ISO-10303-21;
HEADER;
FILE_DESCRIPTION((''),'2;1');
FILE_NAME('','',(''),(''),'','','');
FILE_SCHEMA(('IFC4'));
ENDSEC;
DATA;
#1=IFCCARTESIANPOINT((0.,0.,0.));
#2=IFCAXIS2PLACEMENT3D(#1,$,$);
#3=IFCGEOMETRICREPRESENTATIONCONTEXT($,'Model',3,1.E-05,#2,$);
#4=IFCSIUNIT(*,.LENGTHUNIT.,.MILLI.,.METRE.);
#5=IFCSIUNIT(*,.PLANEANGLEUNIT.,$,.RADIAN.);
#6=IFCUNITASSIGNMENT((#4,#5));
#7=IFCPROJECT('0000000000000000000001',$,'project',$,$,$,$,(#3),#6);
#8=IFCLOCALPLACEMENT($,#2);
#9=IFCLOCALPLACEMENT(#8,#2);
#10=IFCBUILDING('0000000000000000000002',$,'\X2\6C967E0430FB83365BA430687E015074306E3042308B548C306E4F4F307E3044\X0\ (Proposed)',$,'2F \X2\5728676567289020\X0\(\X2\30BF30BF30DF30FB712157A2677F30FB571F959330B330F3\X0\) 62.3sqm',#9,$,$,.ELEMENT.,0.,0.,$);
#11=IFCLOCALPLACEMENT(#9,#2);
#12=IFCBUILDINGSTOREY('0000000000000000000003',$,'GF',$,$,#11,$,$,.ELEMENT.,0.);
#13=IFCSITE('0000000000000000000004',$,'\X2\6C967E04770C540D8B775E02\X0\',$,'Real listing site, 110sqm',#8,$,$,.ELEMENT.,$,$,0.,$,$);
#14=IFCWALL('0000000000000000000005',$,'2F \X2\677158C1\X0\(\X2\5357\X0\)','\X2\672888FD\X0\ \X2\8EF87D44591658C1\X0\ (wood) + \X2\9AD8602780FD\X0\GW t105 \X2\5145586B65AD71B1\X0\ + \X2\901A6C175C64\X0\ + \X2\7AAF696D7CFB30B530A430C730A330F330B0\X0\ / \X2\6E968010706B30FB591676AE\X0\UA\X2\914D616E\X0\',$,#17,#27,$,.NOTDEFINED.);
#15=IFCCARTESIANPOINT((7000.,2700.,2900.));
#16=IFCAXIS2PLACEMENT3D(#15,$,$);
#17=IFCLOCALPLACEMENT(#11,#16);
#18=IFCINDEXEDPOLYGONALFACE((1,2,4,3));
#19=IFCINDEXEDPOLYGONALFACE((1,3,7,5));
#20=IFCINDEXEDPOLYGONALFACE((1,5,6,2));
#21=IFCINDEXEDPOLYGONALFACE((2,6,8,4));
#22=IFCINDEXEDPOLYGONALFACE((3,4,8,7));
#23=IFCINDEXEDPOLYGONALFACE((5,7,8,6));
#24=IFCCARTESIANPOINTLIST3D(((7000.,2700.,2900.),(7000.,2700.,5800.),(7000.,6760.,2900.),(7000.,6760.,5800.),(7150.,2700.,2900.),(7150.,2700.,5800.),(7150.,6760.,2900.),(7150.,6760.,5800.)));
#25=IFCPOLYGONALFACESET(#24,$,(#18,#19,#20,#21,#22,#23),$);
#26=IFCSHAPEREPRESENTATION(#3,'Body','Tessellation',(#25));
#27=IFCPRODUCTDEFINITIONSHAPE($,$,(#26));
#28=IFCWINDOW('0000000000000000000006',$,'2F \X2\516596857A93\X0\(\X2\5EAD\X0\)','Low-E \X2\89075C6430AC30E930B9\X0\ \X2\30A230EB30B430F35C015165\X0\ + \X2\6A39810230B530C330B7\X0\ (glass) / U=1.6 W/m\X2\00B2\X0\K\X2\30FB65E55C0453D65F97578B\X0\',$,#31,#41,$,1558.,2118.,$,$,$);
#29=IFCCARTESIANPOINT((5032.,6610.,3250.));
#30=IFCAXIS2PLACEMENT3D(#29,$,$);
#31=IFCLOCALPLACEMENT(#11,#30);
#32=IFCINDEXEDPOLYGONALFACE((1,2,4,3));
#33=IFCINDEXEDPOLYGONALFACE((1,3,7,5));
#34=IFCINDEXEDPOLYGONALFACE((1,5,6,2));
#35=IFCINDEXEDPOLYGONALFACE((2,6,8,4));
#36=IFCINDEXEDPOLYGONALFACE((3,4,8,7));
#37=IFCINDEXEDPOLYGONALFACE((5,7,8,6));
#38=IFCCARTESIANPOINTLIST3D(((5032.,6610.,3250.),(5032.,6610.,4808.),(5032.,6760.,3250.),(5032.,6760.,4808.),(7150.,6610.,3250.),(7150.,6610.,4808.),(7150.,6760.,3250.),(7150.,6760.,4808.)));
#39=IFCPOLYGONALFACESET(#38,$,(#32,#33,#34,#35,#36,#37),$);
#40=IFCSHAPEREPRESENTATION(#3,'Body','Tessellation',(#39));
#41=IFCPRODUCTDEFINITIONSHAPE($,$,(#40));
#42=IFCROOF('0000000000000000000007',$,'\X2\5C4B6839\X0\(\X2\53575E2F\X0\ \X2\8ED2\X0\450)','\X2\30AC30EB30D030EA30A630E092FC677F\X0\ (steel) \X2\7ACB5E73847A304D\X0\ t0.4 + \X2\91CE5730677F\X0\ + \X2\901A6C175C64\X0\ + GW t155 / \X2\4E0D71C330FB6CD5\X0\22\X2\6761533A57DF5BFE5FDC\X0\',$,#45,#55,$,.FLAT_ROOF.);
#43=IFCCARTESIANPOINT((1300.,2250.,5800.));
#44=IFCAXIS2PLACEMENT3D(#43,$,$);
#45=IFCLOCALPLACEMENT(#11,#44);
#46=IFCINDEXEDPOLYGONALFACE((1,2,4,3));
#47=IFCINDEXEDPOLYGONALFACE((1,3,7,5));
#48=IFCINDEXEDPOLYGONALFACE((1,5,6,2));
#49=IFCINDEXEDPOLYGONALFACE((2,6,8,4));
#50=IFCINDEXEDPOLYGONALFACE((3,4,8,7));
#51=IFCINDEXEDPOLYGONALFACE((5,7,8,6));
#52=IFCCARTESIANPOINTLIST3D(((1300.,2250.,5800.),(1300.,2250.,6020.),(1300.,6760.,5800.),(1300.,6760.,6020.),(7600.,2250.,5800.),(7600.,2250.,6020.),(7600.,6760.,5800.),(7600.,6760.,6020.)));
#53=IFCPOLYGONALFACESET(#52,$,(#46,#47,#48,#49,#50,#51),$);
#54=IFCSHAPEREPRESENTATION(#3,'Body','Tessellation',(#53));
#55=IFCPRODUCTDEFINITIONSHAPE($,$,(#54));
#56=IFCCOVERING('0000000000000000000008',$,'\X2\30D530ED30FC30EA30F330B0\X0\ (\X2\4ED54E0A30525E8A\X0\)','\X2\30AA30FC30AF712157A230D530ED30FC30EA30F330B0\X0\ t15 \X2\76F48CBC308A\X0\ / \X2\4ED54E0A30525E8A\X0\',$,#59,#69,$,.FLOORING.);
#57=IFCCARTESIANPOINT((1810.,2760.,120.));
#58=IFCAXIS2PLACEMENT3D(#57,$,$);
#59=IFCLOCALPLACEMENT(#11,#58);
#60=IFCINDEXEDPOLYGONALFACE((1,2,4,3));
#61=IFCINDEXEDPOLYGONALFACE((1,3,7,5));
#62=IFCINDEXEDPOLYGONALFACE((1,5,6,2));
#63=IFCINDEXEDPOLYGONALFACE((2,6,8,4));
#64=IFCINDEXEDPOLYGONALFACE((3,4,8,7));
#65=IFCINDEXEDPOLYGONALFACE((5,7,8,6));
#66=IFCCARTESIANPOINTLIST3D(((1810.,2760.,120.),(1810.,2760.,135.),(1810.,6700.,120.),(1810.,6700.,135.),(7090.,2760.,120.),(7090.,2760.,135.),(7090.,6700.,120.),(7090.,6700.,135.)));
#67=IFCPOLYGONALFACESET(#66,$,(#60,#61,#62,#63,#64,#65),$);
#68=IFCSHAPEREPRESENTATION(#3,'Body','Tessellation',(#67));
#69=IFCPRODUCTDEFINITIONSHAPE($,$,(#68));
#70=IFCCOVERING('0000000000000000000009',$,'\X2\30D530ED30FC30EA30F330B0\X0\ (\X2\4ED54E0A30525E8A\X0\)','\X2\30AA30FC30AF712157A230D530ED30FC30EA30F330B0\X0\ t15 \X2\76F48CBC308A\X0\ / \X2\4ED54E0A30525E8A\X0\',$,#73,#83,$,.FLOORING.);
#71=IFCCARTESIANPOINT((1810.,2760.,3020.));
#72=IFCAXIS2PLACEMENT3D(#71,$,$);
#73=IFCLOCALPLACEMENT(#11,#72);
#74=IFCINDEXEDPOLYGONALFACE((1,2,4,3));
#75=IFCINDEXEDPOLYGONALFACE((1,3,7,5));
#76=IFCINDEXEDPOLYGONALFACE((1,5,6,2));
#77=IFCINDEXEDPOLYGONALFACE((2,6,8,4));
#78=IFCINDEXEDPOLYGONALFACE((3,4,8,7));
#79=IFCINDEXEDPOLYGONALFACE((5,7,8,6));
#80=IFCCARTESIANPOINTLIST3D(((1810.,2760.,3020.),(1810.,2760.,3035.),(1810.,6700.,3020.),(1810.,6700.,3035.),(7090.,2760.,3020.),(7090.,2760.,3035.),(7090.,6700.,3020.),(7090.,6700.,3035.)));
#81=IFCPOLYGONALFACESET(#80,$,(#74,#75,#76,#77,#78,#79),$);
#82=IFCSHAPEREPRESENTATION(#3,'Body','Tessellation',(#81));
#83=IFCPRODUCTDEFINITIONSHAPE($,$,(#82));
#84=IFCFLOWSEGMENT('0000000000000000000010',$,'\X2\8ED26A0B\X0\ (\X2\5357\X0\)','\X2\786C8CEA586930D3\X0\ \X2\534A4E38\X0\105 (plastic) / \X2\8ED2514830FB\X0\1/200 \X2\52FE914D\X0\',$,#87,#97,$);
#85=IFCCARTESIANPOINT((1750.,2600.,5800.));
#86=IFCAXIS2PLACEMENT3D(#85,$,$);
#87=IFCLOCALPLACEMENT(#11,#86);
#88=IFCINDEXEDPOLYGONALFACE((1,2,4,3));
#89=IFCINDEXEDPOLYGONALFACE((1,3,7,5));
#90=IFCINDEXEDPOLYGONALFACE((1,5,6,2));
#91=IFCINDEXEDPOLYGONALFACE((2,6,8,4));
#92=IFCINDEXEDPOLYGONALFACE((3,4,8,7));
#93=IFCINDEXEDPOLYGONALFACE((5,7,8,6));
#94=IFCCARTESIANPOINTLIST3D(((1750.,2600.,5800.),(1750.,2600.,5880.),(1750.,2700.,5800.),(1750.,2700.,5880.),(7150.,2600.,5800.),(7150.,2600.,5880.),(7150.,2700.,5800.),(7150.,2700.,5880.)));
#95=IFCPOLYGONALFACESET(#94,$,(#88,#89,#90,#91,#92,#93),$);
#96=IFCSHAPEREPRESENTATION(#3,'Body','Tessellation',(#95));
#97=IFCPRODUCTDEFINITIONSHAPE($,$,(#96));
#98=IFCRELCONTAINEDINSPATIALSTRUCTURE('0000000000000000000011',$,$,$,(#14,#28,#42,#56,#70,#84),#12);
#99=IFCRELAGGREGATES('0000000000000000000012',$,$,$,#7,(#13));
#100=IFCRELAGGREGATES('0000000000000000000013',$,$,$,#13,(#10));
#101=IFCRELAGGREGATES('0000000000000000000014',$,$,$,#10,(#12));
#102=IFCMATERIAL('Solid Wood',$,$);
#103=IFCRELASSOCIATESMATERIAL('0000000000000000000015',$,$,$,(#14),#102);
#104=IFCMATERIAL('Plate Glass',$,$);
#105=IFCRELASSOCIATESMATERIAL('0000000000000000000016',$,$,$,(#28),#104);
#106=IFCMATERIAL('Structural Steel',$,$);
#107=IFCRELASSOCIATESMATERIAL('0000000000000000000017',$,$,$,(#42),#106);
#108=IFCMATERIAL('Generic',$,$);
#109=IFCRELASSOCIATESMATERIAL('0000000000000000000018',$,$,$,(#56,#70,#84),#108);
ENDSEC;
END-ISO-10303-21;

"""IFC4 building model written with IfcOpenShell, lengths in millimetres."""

from ifc_helpers import new_model, si_unit, frame, frame_2d, origin, place, context, project, spatial, rectangle, extrude, material, element, fill, save


model = new_model("IFC4")

# Units and contexts
model_context = context("Model", 3, precision=1e-05, world=origin())
ifc_project = project(units=[si_unit("LENGTHUNIT", "METRE", prefix="MILLI"), si_unit("PLANEANGLEUNIT", "RADIAN")], contexts=[model_context])

# Site, building, storey
site_placement = place(None, origin())
site = spatial("IfcSite", under=ifc_project, at=site_placement, Name="沖縄県名護市", ObjectType="Real listing site, 110sqm", CompositionType="ELEMENT", RefElevation=0.0)
building_placement = place(site_placement, origin())
building = spatial("IfcBuilding", under=site, at=building_placement, Name="沖縄・茶室と縁側のある和の住まい (Proposed)", ObjectType="2F 在来木造(タタミ・無垢板・土間コン) 62.3sqm", CompositionType="ELEMENT", ElevationOfRefHeight=0.0, ElevationOfTerrain=0.0)
storey_placement = place(building_placement, origin())
storey = spatial("IfcBuildingStorey", under=building, at=storey_placement, Name="GF", CompositionType="ELEMENT", Elevation=0.0)

# Shared definitions
ifc_material_1 = material(Name="Solid Wood")

# Wall, opening, window
ifc_material_2 = material(Name="Plate Glass")
wall_1_placement = place(storey_placement, frame((7000.0, 2700.0, 2900.0)))
wall_1 = element("IfcWall", 1, at=wall_1_placement, inside=storey, material=ifc_material_1, Name="2F 東壁(南)", Description="木製 軸組外壁 (wood) + 高性能GW t105 充填断熱 + 通気層 + 窯業系サイディング / 準耐火・外皮UA配慮", PredefinedType="NOTDEFINED", context=model_context, shape_type="SweptSolid", body=[
    extrude(rectangle(XDim=150.0, YDim=4060.0, at=frame_2d((75.0, 2030.0))), frame((7000.0, 2700.0, 2900.0)), (0.0, 0.0, 1.0), 2900.0),
])
opening_1_placement = place(storey_placement, frame((5032.0, 6610.0, 3250.0)))
opening_1 = element("IfcOpeningElement", 2, at=opening_1_placement, cuts=wall_1, PredefinedType="NOTDEFINED", context=model_context, shape_type="SweptSolid", body=[
    extrude(rectangle(XDim=2118.0, YDim=150.0, at=frame_2d((1059.0, 75.0))), frame((5032.0, 6610.0, 3250.0)), (0.0, 0.0, 1.0), 1558.0),
])
window_1_placement = place(storey_placement, frame((5032.0, 6610.0, 3250.0)))
window_1 = element("IfcWindow", 3, at=window_1_placement, inside=storey, material=ifc_material_2, Name="2F 入隅窓(庭)", Description="Low-E 複層ガラス アルゴン封入 + 樹脂サッシ (glass) / U=1.6 W/m²K・日射取得型", OverallHeight=1558.0, OverallWidth=2118.0, context=model_context, shape_type="SweptSolid", body=[
    extrude(rectangle(XDim=2118.0, YDim=150.0, at=frame_2d((1059.0, 75.0))), frame((5032.0, 6610.0, 3250.0)), (0.0, 0.0, 1.0), 1558.0),
])
fill(opening_1, window_1)

# Roof
ifc_material_3 = material(Name="Structural Steel")
for number, where, name in (
    (4, (1300.0, 2250.0, 5800.0), "屋根(南帯 軒450)"),
):
    element("IfcRoof", number, at=place(storey_placement, frame(where)), inside=storey, material=ifc_material_3, Name=name, Description="ガルバリウム鋼板 (steel) 立平葺き t0.4 + 野地板 + 通気層 + GW t155 / 不燃・法22条区域対応", PredefinedType="FLAT_ROOF", context=model_context, shape_type="SweptSolid", body=[
        extrude(rectangle(XDim=6300.0, YDim=4510.0, at=frame_2d((3150.0, 2255.0))), frame((1300.0, 2250.0, 5800.0)), (0.0, 0.0, 1.0), 220.0),
    ])

# Coverings
ifc_material_4 = material(Name="Generic")
covering_1_placement = place(storey_placement, frame((1810.0, 2760.0, 120.0)))
element("IfcCovering", 5, at=covering_1_placement, inside=storey, material=ifc_material_4, Name="フローリング (仕上げ床)", Description="オーク無垢フローリング t15 直貼り / 仕上げ床", PredefinedType="FLOORING", context=model_context, shape_type="SweptSolid", body=[
    extrude(rectangle(XDim=5280.0, YDim=3940.0, at=frame_2d((2640.0, 1970.0))), frame((1810.0, 2760.0, 120.0)), (0.0, 0.0, 1.0), 15.0),
])
covering_2_placement = place(storey_placement, frame((1810.0, 2760.0, 3020.0)))
element("IfcCovering", 6, at=covering_2_placement, inside=storey, material=ifc_material_4, Name="フローリング (仕上げ床)", Description="オーク無垢フローリング t15 直貼り / 仕上げ床", PredefinedType="FLOORING", context=model_context, shape_type="SweptSolid", body=[
    extrude(rectangle(XDim=5280.0, YDim=3940.0, at=frame_2d((2640.0, 1970.0))), frame((1810.0, 2760.0, 3020.0)), (0.0, 0.0, 1.0), 15.0),
])

# Flow segment
flow_segment_placement = place(storey_placement, frame((1750.0, 2600.0, 5800.0)))
element("IfcFlowSegment", 7, at=flow_segment_placement, inside=storey, material=ifc_material_4, Name="軒樋 (南)", Description="硬質塩ビ 半丸105 (plastic) / 軒先・1/200 勾配", context=model_context, shape_type="SweptSolid", body=[
    extrude(rectangle(XDim=5400.0, YDim=100.0, at=frame_2d((2700.0, 50.0))), frame((1750.0, 2600.0, 5800.0)), (0.0, 0.0, 1.0), 80.0),
])

save(model, "model.ifc")
